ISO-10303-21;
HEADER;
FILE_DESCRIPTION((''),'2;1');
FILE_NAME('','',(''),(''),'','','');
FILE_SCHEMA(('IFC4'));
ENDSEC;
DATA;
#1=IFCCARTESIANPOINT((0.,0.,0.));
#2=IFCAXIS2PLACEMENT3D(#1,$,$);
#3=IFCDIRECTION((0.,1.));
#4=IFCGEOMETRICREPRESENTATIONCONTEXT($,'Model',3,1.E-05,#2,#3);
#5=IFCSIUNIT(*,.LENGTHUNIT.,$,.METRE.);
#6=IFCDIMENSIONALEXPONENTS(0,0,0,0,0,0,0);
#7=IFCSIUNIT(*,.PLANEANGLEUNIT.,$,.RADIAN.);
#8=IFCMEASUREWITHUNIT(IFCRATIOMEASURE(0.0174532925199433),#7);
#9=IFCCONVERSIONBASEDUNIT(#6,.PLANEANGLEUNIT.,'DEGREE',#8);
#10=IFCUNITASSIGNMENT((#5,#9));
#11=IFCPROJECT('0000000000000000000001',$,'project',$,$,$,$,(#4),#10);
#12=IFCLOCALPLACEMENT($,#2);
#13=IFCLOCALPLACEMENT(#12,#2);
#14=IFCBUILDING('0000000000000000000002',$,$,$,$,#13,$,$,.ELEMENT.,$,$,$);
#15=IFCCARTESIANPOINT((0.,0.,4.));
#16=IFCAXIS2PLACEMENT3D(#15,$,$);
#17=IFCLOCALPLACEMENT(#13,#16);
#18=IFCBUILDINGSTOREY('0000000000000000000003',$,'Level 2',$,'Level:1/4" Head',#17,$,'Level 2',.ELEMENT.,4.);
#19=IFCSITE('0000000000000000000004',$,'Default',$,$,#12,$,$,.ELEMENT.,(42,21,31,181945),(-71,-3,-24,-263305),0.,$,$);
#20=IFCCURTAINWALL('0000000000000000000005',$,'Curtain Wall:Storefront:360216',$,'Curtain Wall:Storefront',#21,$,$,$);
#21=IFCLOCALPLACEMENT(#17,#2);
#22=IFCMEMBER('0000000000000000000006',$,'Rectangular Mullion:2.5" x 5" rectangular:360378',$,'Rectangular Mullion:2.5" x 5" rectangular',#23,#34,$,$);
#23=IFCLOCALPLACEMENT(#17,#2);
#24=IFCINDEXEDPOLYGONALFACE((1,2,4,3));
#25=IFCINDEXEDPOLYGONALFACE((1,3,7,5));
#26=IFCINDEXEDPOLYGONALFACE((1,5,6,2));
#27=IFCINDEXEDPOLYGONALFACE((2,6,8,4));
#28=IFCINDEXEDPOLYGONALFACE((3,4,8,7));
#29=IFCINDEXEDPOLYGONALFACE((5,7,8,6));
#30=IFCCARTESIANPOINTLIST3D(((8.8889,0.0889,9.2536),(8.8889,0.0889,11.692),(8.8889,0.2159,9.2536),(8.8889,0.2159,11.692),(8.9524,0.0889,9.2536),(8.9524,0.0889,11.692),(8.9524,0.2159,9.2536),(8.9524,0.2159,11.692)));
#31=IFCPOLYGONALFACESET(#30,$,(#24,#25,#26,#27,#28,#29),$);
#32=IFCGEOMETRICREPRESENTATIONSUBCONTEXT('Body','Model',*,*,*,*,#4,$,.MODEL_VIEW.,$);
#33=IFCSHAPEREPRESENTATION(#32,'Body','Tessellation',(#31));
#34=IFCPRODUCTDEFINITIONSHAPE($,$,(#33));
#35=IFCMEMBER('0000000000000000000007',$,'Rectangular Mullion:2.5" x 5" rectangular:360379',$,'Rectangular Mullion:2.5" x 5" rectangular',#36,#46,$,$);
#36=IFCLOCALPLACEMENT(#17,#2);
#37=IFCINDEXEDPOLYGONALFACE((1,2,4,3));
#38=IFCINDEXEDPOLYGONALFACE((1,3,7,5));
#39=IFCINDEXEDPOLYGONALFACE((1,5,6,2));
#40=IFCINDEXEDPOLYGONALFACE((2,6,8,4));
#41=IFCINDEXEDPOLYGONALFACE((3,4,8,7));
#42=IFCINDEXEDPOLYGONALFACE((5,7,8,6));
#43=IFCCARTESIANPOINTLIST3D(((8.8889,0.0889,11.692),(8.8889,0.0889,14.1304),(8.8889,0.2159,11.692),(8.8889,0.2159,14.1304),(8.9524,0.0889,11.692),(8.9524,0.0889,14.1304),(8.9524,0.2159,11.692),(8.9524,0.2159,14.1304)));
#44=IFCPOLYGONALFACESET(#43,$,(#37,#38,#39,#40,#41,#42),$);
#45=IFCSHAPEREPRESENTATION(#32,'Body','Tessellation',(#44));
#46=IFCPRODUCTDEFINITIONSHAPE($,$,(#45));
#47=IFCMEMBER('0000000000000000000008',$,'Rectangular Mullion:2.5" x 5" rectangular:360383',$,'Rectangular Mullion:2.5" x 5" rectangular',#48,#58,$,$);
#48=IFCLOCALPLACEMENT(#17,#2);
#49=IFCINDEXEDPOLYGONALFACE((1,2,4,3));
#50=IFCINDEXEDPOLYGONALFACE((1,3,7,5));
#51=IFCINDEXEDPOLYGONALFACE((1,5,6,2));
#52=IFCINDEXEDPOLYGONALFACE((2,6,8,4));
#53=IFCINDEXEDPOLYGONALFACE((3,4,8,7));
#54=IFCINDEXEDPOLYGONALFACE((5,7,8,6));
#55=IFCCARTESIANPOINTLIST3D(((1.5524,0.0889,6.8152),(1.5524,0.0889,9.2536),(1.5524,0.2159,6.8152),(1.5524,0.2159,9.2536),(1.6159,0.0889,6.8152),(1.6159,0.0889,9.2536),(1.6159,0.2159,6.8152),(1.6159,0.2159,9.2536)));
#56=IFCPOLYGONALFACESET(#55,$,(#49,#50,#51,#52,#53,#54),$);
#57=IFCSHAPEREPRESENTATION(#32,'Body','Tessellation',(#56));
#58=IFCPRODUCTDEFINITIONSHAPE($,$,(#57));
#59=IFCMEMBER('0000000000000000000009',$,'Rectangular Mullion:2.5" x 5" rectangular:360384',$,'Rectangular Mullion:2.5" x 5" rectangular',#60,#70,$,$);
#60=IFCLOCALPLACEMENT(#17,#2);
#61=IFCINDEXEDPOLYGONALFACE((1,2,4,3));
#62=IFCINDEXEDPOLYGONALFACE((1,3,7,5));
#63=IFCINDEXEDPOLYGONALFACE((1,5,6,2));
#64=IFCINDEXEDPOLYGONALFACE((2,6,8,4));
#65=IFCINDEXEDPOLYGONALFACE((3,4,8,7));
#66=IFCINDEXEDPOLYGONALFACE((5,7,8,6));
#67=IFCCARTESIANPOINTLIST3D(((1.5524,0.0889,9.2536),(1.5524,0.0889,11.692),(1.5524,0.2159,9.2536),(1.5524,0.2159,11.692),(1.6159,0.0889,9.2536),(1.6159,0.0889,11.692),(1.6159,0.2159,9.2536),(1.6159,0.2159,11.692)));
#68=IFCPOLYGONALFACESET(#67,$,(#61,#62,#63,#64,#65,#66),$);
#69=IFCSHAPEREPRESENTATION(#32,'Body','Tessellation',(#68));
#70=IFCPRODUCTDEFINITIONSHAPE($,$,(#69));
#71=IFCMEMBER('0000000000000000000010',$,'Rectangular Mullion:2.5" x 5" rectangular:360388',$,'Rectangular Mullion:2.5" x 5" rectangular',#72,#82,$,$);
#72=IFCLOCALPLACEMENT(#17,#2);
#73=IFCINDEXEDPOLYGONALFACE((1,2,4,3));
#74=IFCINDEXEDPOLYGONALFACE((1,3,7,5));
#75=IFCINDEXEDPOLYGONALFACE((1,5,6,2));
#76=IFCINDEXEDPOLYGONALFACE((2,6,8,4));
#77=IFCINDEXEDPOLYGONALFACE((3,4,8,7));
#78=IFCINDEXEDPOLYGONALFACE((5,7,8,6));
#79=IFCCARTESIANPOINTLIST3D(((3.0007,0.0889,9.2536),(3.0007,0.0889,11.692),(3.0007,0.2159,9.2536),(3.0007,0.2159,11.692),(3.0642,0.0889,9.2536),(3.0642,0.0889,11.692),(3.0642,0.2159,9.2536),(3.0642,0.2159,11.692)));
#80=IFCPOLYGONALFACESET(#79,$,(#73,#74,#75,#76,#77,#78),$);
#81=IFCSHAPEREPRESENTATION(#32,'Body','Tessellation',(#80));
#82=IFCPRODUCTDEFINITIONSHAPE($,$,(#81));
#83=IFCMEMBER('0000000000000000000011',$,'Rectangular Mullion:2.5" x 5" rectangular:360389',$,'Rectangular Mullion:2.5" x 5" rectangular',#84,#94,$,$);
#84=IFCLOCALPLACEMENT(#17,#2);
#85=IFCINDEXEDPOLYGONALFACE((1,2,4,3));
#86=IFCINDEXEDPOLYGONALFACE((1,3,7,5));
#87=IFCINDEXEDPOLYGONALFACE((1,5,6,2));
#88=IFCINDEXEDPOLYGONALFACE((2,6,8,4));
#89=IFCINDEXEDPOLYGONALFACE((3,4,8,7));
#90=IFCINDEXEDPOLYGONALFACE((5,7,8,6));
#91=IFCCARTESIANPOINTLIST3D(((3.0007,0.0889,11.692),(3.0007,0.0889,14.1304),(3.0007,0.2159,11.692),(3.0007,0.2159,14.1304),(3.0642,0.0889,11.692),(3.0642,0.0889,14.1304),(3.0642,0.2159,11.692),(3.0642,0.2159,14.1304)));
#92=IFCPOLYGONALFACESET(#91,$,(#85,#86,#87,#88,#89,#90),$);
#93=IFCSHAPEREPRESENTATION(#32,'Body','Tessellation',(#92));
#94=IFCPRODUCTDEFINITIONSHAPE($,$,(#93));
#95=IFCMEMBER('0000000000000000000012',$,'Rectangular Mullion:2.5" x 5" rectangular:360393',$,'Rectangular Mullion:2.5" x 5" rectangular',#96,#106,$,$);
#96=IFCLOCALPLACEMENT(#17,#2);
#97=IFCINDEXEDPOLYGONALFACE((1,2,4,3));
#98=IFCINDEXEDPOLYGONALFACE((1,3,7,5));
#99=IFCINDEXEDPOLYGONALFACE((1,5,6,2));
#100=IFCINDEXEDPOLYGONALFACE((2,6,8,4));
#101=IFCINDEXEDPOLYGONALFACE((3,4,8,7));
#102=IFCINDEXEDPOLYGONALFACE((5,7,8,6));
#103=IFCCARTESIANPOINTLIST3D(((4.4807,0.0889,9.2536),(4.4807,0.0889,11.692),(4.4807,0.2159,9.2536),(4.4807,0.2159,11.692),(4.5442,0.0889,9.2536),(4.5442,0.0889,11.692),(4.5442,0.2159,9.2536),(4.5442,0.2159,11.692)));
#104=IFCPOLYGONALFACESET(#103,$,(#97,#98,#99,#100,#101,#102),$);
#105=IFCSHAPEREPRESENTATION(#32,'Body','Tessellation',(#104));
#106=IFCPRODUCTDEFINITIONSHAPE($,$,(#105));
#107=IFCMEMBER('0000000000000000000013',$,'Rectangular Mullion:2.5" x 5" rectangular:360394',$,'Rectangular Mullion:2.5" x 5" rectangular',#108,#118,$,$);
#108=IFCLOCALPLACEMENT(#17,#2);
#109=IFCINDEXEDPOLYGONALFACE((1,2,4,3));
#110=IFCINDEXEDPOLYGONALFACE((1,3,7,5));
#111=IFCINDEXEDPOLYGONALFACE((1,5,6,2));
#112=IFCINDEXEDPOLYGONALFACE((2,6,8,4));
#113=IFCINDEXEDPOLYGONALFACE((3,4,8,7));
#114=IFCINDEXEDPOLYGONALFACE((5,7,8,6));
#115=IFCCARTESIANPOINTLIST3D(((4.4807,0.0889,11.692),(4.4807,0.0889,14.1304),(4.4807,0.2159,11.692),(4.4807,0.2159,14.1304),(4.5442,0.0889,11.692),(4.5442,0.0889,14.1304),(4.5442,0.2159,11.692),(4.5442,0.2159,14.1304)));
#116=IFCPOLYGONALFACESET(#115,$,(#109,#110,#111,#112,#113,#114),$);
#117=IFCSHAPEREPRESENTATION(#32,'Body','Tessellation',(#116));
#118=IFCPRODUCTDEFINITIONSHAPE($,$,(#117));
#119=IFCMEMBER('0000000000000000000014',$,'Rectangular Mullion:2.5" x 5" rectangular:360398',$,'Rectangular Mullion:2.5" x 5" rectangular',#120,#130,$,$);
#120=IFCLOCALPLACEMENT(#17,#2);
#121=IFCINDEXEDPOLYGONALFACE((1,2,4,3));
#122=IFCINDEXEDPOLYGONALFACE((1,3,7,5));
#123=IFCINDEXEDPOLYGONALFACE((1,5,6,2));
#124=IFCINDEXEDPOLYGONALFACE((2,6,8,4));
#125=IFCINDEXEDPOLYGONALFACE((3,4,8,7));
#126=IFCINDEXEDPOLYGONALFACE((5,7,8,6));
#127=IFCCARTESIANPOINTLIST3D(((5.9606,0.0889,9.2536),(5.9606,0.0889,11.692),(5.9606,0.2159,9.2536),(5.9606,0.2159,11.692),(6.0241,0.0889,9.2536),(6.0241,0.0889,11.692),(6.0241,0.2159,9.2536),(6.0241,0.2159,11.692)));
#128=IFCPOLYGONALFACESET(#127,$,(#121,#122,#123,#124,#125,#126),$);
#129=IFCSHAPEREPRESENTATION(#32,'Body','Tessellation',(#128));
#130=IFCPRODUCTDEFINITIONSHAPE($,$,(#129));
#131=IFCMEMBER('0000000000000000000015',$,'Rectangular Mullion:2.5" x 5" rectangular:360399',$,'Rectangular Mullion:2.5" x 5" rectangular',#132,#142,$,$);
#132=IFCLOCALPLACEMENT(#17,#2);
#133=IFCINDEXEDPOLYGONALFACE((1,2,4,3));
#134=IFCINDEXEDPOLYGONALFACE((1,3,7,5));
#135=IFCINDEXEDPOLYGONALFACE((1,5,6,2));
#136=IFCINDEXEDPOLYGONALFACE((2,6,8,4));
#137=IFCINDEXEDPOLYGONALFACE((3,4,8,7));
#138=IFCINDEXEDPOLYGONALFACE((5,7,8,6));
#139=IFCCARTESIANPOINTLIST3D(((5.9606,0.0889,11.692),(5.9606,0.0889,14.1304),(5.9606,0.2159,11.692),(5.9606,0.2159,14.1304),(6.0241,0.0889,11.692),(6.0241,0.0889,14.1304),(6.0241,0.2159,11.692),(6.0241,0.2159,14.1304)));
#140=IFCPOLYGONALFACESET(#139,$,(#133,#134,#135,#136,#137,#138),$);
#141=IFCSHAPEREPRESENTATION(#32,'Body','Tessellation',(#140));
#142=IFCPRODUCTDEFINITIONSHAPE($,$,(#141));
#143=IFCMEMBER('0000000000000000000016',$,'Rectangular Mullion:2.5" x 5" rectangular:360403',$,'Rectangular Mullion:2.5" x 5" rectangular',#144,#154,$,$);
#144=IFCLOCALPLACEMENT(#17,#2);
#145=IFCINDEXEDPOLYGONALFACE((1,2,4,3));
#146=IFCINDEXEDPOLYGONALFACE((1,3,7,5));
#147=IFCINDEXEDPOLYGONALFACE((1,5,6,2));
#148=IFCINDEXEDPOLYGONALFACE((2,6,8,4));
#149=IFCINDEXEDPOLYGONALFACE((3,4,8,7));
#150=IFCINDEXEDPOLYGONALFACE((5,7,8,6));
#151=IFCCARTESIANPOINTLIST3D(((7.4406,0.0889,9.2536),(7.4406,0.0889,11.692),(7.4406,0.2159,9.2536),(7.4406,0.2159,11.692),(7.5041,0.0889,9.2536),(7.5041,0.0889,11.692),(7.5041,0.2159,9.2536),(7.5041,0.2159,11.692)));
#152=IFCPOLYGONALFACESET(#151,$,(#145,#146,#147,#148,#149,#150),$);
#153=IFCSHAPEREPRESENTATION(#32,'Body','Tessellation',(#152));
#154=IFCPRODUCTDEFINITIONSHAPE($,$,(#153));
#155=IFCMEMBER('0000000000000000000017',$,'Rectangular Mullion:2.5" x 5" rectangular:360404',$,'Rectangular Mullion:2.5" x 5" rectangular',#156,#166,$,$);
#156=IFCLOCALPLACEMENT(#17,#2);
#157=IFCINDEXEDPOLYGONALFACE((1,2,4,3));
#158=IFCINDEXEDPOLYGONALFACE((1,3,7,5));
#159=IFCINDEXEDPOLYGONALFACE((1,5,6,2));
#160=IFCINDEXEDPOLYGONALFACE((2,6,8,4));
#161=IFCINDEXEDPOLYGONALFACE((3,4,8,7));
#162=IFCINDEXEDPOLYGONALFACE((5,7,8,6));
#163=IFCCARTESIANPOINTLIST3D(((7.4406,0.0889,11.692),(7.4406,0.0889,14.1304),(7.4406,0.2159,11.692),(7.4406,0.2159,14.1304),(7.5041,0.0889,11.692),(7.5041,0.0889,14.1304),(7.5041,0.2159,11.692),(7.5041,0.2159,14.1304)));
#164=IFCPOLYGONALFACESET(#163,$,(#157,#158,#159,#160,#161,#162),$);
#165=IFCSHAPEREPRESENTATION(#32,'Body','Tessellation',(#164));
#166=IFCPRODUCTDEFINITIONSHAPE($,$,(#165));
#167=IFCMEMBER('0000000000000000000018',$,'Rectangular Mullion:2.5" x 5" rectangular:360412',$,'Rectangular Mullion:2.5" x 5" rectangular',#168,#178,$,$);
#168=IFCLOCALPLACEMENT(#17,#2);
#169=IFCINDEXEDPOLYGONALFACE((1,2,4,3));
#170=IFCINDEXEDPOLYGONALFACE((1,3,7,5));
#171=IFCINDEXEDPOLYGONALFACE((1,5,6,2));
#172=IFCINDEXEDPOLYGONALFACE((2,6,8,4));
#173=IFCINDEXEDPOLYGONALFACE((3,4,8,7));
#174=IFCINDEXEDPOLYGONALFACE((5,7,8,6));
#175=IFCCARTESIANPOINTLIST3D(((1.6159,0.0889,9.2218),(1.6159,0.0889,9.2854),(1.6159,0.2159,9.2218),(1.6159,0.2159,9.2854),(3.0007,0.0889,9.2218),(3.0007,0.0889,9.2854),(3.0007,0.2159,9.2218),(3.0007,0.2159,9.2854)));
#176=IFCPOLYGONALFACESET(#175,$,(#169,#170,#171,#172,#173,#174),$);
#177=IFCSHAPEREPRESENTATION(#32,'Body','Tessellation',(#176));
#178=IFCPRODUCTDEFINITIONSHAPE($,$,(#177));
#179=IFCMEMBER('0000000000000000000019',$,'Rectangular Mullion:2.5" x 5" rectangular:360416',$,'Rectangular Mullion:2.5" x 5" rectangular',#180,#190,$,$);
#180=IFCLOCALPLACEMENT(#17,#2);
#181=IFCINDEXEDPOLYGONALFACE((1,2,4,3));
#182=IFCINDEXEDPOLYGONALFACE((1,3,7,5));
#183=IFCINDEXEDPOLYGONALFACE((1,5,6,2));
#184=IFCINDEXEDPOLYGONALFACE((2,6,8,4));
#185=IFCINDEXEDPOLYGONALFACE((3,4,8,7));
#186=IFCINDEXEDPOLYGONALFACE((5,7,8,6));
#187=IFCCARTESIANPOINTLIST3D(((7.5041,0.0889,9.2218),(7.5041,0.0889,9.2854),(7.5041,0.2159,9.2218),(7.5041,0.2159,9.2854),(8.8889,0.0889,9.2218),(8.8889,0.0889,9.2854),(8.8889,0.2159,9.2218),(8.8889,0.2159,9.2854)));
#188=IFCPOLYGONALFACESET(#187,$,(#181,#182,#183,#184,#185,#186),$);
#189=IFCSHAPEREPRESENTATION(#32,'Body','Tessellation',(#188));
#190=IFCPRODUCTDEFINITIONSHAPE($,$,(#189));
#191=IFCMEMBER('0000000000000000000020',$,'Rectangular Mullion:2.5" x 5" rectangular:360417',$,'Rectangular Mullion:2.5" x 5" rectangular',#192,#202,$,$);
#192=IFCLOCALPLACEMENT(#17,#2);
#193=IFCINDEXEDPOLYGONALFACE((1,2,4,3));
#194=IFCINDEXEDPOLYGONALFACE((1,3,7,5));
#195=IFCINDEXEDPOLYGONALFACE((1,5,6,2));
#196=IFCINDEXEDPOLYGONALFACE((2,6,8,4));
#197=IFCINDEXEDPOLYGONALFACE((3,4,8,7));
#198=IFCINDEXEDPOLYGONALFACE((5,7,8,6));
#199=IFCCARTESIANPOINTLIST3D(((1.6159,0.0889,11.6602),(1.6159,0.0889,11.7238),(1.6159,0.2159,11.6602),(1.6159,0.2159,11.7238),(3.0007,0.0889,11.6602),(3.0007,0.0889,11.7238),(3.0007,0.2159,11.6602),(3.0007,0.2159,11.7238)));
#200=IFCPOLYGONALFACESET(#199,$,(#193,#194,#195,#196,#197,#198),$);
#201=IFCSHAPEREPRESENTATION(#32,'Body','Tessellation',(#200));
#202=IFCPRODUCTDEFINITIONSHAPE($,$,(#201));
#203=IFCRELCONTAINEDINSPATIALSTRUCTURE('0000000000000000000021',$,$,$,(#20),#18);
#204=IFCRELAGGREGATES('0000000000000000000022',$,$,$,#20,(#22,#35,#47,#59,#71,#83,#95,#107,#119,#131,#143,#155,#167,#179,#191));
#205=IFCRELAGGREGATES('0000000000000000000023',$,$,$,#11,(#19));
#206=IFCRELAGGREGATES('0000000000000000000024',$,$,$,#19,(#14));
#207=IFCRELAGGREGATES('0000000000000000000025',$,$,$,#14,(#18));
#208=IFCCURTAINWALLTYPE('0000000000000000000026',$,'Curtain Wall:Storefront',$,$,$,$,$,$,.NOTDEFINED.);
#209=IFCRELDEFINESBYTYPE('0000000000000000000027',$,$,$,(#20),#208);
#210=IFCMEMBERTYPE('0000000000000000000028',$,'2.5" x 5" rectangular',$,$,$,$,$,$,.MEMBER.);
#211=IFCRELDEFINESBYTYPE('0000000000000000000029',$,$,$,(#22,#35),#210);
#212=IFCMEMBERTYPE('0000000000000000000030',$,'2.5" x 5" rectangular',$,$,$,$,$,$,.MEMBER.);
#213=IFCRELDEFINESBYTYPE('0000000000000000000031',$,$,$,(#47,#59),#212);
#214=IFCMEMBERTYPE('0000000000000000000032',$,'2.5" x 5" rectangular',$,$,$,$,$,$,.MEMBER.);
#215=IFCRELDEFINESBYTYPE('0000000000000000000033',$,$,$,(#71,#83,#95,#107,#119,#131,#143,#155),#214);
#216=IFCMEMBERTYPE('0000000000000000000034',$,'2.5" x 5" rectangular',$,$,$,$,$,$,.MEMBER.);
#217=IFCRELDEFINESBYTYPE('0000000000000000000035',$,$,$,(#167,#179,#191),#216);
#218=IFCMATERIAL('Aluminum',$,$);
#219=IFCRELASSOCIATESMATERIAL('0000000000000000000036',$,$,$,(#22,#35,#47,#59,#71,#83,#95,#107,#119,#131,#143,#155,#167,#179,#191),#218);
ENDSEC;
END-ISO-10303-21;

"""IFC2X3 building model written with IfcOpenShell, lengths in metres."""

from ifc_helpers import new_model, entity, si_unit, converted_unit, direction, frame, origin, origin_2d_with_axis, place, context, subcontext, project, spatial, rectangle, extrude, source, transform, mapped, material, type_object, type_shapes, element, aggregate, save


model = new_model("IFC2X3")

# Units and contexts
model_context = context("Model", 3, precision=1e-05, world=origin(), true_north=direction((0.0, 1.0)))
body_context = subcontext(model_context, "Body", "Model", "MODEL_VIEW")
ifc_project = project(units=[si_unit("LENGTHUNIT", "METRE"), converted_unit("PLANEANGLEUNIT", "DEGREE", entity("IfcRatioMeasure", 0.0174532925199433), si_unit("PLANEANGLEUNIT", "RADIAN"), dimensions=[0, 0, 0, 0, 0, 0, 0])], contexts=[model_context])

# Site, building, storey
site_placement = place(None, origin())
site = spatial("IfcSite", under=ifc_project, at=site_placement, Name="Default", CompositionType="ELEMENT", RefLatitude=(42, 21, 31, 181945), RefLongitude=(-71, -3, -24, -263305), RefElevation=0.0)
building_placement = place(site_placement, origin())
building = spatial("IfcBuilding", under=site, at=building_placement, CompositionType="ELEMENT")
storey_placement = place(building_placement, frame((0.0, 0.0, 4.0)))
storey = spatial("IfcBuildingStorey", under=building, at=storey_placement, Name="Level 2", ObjectType="Level:1/4\" Head", LongName="Level 2", CompositionType="ELEMENT", Elevation=4.0)

# Curtain wall, members
curtain_wall_type = type_object("IfcCurtainWallType", Name="Curtain Wall:Storefront", PredefinedType="NOTDEFINED")
curtain_wall_placement = place(storey_placement, frame((0.0, 0.0, -4.0)))
curtain_wall = element("IfcCurtainWall", 1, at=curtain_wall_placement, inside=storey, type_object=curtain_wall_type, Name="Curtain Wall:Storefront:360216", ObjectType="Curtain Wall:Storefront")
ifc_material_1 = material(Name="Aluminum")
member_type_1 = type_object("IfcMemberType", Name="2.5\" x 5\" rectangular", PredefinedType="MEMBER")
shared_shape_1 = source(origin(), body_context, "Body", "SweptSolid", [
    extrude(rectangle(XDim=0.127, YDim=0.0635, at=origin_2d_with_axis()), frame((-0.0318, 0.0, -2.4384), z_axis=(0.0, 0.0, 1.0), x_axis=(0.0, -1.0, 0.0)), (0.0, 0.0, 1.0), 2.4384),
])
type_shapes(member_type_1, [shared_shape_1])
member_1_placement = place(storey_placement, frame((8.9524, 0.1524, 9.2536), z_axis=(0.0, 0.0, -1.0), x_axis=(1.0, 0.0, 0.0)))
member_1 = element("IfcMember", 2, at=member_1_placement, type_object=member_type_1, material=ifc_material_1, Name="Rectangular Mullion:2.5\" x 5\" rectangular:360378", ObjectType="Rectangular Mullion:2.5\" x 5\" rectangular", context=body_context, shape_type="MappedRepresentation", body=[
    mapped(shared_shape_1, transform((0.0, 0.0, 0.0), scale=1.0)),
])
member_2_placement = place(storey_placement, frame((8.9524, 0.1524, 11.692), z_axis=(0.0, 0.0, -1.0), x_axis=(1.0, 0.0, 0.0)))
member_2 = element("IfcMember", 3, at=member_2_placement, type_object=member_type_1, material=ifc_material_1, Name="Rectangular Mullion:2.5\" x 5\" rectangular:360379", ObjectType="Rectangular Mullion:2.5\" x 5\" rectangular", context=body_context, shape_type="MappedRepresentation", body=[
    mapped(shared_shape_1, transform((0.0, 0.0, 0.0), scale=1.0)),
])
member_type_2 = type_object("IfcMemberType", Name="2.5\" x 5\" rectangular", PredefinedType="MEMBER")
shared_shape_2 = source(origin(), body_context, "Body", "SweptSolid", [
    extrude(rectangle(XDim=0.127, YDim=0.0635, at=origin_2d_with_axis()), frame((-0.0318, 0.0, -2.4384), z_axis=(0.0, 0.0, 1.0), x_axis=(0.0, -1.0, 0.0)), (0.0, 0.0, 1.0), 2.4384),
])
type_shapes(member_type_2, [shared_shape_2])
member_3_placement = place(storey_placement, frame((1.5524, 0.1524, 9.2536), z_axis=(0.0, 0.0, 1.0), x_axis=(-1.0, 0.0, 0.0)))
member_3 = element("IfcMember", 4, at=member_3_placement, type_object=member_type_2, material=ifc_material_1, Name="Rectangular Mullion:2.5\" x 5\" rectangular:360383", ObjectType="Rectangular Mullion:2.5\" x 5\" rectangular", context=body_context, shape_type="MappedRepresentation", body=[
    mapped(shared_shape_2, transform((0.0, 0.0, 0.0), scale=1.0)),
])
member_4_placement = place(storey_placement, frame((1.5524, 0.1524, 11.692), z_axis=(0.0, 0.0, 1.0), x_axis=(-1.0, 0.0, 0.0)))
member_4 = element("IfcMember", 5, at=member_4_placement, type_object=member_type_2, material=ifc_material_1, Name="Rectangular Mullion:2.5\" x 5\" rectangular:360384", ObjectType="Rectangular Mullion:2.5\" x 5\" rectangular", context=body_context, shape_type="MappedRepresentation", body=[
    mapped(shared_shape_2, transform((0.0, 0.0, 0.0), scale=1.0)),
])
member_type_3 = type_object("IfcMemberType", Name="2.5\" x 5\" rectangular", PredefinedType="MEMBER")
shared_shape_3 = source(origin(), body_context, "Body", "SweptSolid", [
    extrude(rectangle(XDim=0.127, YDim=0.0635, at=origin_2d_with_axis()), frame((0.0, 0.0, -2.4384), z_axis=(0.0, 0.0, 1.0), x_axis=(0.0, -1.0, 0.0)), (0.0, 0.0, 1.0), 2.4384),
])
type_shapes(member_type_3, [shared_shape_3])
member_5_placement = place(storey_placement, frame((3.0324, 0.1524, 9.2536), z_axis=(0.0, 0.0, -1.0), x_axis=(1.0, 0.0, 0.0)))
member_5 = element("IfcMember", 6, at=member_5_placement, type_object=member_type_3, material=ifc_material_1, Name="Rectangular Mullion:2.5\" x 5\" rectangular:360388", ObjectType="Rectangular Mullion:2.5\" x 5\" rectangular", context=body_context, shape_type="MappedRepresentation", body=[
    mapped(shared_shape_3, transform((0.0, 0.0, 0.0), scale=1.0)),
])
member_6_placement = place(storey_placement, frame((3.0324, 0.1524, 11.692), z_axis=(0.0, 0.0, -1.0), x_axis=(1.0, 0.0, 0.0)))
member_6 = element("IfcMember", 7, at=member_6_placement, type_object=member_type_3, material=ifc_material_1, Name="Rectangular Mullion:2.5\" x 5\" rectangular:360389", ObjectType="Rectangular Mullion:2.5\" x 5\" rectangular", context=body_context, shape_type="MappedRepresentation", body=[
    mapped(shared_shape_3, transform((0.0, 0.0, 0.0), scale=1.0)),
])
member_7_placement = place(storey_placement, frame((4.5124, 0.1524, 9.2536), z_axis=(0.0, 0.0, -1.0), x_axis=(1.0, 0.0, 0.0)))
member_7 = element("IfcMember", 8, at=member_7_placement, type_object=member_type_3, material=ifc_material_1, Name="Rectangular Mullion:2.5\" x 5\" rectangular:360393", ObjectType="Rectangular Mullion:2.5\" x 5\" rectangular", context=body_context, shape_type="MappedRepresentation", body=[
    mapped(shared_shape_3, transform((0.0, 0.0, 0.0), scale=1.0)),
])
member_8_placement = place(storey_placement, frame((4.5124, 0.1524, 11.692), z_axis=(0.0, 0.0, -1.0), x_axis=(1.0, 0.0, 0.0)))
member_8 = element("IfcMember", 9, at=member_8_placement, type_object=member_type_3, material=ifc_material_1, Name="Rectangular Mullion:2.5\" x 5\" rectangular:360394", ObjectType="Rectangular Mullion:2.5\" x 5\" rectangular", context=body_context, shape_type="MappedRepresentation", body=[
    mapped(shared_shape_3, transform((0.0, 0.0, 0.0), scale=1.0)),
])
member_9_placement = place(storey_placement, frame((5.9924, 0.1524, 9.2536), z_axis=(0.0, 0.0, -1.0), x_axis=(1.0, 0.0, 0.0)))
member_9 = element("IfcMember", 10, at=member_9_placement, type_object=member_type_3, material=ifc_material_1, Name="Rectangular Mullion:2.5\" x 5\" rectangular:360398", ObjectType="Rectangular Mullion:2.5\" x 5\" rectangular", context=body_context, shape_type="MappedRepresentation", body=[
    mapped(shared_shape_3, transform((0.0, 0.0, 0.0), scale=1.0)),
])
member_10_placement = place(storey_placement, frame((5.9924, 0.1524, 11.692), z_axis=(0.0, 0.0, -1.0), x_axis=(1.0, 0.0, 0.0)))
member_10 = element("IfcMember", 11, at=member_10_placement, type_object=member_type_3, material=ifc_material_1, Name="Rectangular Mullion:2.5\" x 5\" rectangular:360399", ObjectType="Rectangular Mullion:2.5\" x 5\" rectangular", context=body_context, shape_type="MappedRepresentation", body=[
    mapped(shared_shape_3, transform((0.0, 0.0, 0.0), scale=1.0)),
])
member_11_placement = place(storey_placement, frame((7.4724, 0.1524, 9.2536), z_axis=(0.0, 0.0, -1.0), x_axis=(1.0, 0.0, 0.0)))
member_11 = element("IfcMember", 12, at=member_11_placement, type_object=member_type_3, material=ifc_material_1, Name="Rectangular Mullion:2.5\" x 5\" rectangular:360403", ObjectType="Rectangular Mullion:2.5\" x 5\" rectangular", context=body_context, shape_type="MappedRepresentation", body=[
    mapped(shared_shape_3, transform((0.0, 0.0, 0.0), scale=1.0)),
])
member_12_placement = place(storey_placement, frame((7.4724, 0.1524, 11.692), z_axis=(0.0, 0.0, -1.0), x_axis=(1.0, 0.0, 0.0)))
member_12 = element("IfcMember", 13, at=member_12_placement, type_object=member_type_3, material=ifc_material_1, Name="Rectangular Mullion:2.5\" x 5\" rectangular:360404", ObjectType="Rectangular Mullion:2.5\" x 5\" rectangular", context=body_context, shape_type="MappedRepresentation", body=[
    mapped(shared_shape_3, transform((0.0, 0.0, 0.0), scale=1.0)),
])
member_type_4 = type_object("IfcMemberType", Name="2.5\" x 5\" rectangular", PredefinedType="MEMBER")
shared_shape_4 = source(origin(), body_context, "Body", "SweptSolid", [
    extrude(rectangle(XDim=0.127, YDim=0.0635, at=origin_2d_with_axis()), frame((0.0, 0.0, -1.3848), z_axis=(0.0, 0.0, 1.0), x_axis=(0.0, -1.0, 0.0)), (0.0, 0.0, 1.0), 1.3848),
])
type_shapes(member_type_4, [shared_shape_4])
member_13_placement = place(storey_placement, frame((3.0007, 0.1524, 9.2536), z_axis=(1.0, 0.0, 0.0), x_axis=(0.0, 0.0, 1.0)))
member_13 = element("IfcMember", 14, at=member_13_placement, type_object=member_type_4, material=ifc_material_1, Name="Rectangular Mullion:2.5\" x 5\" rectangular:360412", ObjectType="Rectangular Mullion:2.5\" x 5\" rectangular", context=body_context, shape_type="MappedRepresentation", body=[
    mapped(shared_shape_4, transform((0.0, 0.0, 0.0), scale=1.0)),
])
member_14_placement = place(storey_placement, frame((8.8889, 0.1524, 9.2536), z_axis=(1.0, 0.0, 0.0), x_axis=(0.0, 0.0, 1.0)))
member_14 = element("IfcMember", 15, at=member_14_placement, type_object=member_type_4, material=ifc_material_1, Name="Rectangular Mullion:2.5\" x 5\" rectangular:360416", ObjectType="Rectangular Mullion:2.5\" x 5\" rectangular", context=body_context, shape_type="MappedRepresentation", body=[
    mapped(shared_shape_4, transform((0.0, 0.0, 0.0), scale=1.0)),
])
member_15_placement = place(storey_placement, frame((3.0007, 0.1524, 11.692), z_axis=(1.0, 0.0, 0.0), x_axis=(0.0, 0.0, 1.0)))
member_15 = element("IfcMember", 16, at=member_15_placement, type_object=member_type_4, material=ifc_material_1, Name="Rectangular Mullion:2.5\" x 5\" rectangular:360417", ObjectType="Rectangular Mullion:2.5\" x 5\" rectangular", context=body_context, shape_type="MappedRepresentation", body=[
    mapped(shared_shape_4, transform((0.0, 0.0, 0.0), scale=1.0)),
])
aggregate(curtain_wall, [member_1, member_2, member_3, member_4, member_5, member_6, member_7, member_8, member_9, member_10, member_11, member_12, member_13, member_14, member_15])

save(model, "model.ifc")
